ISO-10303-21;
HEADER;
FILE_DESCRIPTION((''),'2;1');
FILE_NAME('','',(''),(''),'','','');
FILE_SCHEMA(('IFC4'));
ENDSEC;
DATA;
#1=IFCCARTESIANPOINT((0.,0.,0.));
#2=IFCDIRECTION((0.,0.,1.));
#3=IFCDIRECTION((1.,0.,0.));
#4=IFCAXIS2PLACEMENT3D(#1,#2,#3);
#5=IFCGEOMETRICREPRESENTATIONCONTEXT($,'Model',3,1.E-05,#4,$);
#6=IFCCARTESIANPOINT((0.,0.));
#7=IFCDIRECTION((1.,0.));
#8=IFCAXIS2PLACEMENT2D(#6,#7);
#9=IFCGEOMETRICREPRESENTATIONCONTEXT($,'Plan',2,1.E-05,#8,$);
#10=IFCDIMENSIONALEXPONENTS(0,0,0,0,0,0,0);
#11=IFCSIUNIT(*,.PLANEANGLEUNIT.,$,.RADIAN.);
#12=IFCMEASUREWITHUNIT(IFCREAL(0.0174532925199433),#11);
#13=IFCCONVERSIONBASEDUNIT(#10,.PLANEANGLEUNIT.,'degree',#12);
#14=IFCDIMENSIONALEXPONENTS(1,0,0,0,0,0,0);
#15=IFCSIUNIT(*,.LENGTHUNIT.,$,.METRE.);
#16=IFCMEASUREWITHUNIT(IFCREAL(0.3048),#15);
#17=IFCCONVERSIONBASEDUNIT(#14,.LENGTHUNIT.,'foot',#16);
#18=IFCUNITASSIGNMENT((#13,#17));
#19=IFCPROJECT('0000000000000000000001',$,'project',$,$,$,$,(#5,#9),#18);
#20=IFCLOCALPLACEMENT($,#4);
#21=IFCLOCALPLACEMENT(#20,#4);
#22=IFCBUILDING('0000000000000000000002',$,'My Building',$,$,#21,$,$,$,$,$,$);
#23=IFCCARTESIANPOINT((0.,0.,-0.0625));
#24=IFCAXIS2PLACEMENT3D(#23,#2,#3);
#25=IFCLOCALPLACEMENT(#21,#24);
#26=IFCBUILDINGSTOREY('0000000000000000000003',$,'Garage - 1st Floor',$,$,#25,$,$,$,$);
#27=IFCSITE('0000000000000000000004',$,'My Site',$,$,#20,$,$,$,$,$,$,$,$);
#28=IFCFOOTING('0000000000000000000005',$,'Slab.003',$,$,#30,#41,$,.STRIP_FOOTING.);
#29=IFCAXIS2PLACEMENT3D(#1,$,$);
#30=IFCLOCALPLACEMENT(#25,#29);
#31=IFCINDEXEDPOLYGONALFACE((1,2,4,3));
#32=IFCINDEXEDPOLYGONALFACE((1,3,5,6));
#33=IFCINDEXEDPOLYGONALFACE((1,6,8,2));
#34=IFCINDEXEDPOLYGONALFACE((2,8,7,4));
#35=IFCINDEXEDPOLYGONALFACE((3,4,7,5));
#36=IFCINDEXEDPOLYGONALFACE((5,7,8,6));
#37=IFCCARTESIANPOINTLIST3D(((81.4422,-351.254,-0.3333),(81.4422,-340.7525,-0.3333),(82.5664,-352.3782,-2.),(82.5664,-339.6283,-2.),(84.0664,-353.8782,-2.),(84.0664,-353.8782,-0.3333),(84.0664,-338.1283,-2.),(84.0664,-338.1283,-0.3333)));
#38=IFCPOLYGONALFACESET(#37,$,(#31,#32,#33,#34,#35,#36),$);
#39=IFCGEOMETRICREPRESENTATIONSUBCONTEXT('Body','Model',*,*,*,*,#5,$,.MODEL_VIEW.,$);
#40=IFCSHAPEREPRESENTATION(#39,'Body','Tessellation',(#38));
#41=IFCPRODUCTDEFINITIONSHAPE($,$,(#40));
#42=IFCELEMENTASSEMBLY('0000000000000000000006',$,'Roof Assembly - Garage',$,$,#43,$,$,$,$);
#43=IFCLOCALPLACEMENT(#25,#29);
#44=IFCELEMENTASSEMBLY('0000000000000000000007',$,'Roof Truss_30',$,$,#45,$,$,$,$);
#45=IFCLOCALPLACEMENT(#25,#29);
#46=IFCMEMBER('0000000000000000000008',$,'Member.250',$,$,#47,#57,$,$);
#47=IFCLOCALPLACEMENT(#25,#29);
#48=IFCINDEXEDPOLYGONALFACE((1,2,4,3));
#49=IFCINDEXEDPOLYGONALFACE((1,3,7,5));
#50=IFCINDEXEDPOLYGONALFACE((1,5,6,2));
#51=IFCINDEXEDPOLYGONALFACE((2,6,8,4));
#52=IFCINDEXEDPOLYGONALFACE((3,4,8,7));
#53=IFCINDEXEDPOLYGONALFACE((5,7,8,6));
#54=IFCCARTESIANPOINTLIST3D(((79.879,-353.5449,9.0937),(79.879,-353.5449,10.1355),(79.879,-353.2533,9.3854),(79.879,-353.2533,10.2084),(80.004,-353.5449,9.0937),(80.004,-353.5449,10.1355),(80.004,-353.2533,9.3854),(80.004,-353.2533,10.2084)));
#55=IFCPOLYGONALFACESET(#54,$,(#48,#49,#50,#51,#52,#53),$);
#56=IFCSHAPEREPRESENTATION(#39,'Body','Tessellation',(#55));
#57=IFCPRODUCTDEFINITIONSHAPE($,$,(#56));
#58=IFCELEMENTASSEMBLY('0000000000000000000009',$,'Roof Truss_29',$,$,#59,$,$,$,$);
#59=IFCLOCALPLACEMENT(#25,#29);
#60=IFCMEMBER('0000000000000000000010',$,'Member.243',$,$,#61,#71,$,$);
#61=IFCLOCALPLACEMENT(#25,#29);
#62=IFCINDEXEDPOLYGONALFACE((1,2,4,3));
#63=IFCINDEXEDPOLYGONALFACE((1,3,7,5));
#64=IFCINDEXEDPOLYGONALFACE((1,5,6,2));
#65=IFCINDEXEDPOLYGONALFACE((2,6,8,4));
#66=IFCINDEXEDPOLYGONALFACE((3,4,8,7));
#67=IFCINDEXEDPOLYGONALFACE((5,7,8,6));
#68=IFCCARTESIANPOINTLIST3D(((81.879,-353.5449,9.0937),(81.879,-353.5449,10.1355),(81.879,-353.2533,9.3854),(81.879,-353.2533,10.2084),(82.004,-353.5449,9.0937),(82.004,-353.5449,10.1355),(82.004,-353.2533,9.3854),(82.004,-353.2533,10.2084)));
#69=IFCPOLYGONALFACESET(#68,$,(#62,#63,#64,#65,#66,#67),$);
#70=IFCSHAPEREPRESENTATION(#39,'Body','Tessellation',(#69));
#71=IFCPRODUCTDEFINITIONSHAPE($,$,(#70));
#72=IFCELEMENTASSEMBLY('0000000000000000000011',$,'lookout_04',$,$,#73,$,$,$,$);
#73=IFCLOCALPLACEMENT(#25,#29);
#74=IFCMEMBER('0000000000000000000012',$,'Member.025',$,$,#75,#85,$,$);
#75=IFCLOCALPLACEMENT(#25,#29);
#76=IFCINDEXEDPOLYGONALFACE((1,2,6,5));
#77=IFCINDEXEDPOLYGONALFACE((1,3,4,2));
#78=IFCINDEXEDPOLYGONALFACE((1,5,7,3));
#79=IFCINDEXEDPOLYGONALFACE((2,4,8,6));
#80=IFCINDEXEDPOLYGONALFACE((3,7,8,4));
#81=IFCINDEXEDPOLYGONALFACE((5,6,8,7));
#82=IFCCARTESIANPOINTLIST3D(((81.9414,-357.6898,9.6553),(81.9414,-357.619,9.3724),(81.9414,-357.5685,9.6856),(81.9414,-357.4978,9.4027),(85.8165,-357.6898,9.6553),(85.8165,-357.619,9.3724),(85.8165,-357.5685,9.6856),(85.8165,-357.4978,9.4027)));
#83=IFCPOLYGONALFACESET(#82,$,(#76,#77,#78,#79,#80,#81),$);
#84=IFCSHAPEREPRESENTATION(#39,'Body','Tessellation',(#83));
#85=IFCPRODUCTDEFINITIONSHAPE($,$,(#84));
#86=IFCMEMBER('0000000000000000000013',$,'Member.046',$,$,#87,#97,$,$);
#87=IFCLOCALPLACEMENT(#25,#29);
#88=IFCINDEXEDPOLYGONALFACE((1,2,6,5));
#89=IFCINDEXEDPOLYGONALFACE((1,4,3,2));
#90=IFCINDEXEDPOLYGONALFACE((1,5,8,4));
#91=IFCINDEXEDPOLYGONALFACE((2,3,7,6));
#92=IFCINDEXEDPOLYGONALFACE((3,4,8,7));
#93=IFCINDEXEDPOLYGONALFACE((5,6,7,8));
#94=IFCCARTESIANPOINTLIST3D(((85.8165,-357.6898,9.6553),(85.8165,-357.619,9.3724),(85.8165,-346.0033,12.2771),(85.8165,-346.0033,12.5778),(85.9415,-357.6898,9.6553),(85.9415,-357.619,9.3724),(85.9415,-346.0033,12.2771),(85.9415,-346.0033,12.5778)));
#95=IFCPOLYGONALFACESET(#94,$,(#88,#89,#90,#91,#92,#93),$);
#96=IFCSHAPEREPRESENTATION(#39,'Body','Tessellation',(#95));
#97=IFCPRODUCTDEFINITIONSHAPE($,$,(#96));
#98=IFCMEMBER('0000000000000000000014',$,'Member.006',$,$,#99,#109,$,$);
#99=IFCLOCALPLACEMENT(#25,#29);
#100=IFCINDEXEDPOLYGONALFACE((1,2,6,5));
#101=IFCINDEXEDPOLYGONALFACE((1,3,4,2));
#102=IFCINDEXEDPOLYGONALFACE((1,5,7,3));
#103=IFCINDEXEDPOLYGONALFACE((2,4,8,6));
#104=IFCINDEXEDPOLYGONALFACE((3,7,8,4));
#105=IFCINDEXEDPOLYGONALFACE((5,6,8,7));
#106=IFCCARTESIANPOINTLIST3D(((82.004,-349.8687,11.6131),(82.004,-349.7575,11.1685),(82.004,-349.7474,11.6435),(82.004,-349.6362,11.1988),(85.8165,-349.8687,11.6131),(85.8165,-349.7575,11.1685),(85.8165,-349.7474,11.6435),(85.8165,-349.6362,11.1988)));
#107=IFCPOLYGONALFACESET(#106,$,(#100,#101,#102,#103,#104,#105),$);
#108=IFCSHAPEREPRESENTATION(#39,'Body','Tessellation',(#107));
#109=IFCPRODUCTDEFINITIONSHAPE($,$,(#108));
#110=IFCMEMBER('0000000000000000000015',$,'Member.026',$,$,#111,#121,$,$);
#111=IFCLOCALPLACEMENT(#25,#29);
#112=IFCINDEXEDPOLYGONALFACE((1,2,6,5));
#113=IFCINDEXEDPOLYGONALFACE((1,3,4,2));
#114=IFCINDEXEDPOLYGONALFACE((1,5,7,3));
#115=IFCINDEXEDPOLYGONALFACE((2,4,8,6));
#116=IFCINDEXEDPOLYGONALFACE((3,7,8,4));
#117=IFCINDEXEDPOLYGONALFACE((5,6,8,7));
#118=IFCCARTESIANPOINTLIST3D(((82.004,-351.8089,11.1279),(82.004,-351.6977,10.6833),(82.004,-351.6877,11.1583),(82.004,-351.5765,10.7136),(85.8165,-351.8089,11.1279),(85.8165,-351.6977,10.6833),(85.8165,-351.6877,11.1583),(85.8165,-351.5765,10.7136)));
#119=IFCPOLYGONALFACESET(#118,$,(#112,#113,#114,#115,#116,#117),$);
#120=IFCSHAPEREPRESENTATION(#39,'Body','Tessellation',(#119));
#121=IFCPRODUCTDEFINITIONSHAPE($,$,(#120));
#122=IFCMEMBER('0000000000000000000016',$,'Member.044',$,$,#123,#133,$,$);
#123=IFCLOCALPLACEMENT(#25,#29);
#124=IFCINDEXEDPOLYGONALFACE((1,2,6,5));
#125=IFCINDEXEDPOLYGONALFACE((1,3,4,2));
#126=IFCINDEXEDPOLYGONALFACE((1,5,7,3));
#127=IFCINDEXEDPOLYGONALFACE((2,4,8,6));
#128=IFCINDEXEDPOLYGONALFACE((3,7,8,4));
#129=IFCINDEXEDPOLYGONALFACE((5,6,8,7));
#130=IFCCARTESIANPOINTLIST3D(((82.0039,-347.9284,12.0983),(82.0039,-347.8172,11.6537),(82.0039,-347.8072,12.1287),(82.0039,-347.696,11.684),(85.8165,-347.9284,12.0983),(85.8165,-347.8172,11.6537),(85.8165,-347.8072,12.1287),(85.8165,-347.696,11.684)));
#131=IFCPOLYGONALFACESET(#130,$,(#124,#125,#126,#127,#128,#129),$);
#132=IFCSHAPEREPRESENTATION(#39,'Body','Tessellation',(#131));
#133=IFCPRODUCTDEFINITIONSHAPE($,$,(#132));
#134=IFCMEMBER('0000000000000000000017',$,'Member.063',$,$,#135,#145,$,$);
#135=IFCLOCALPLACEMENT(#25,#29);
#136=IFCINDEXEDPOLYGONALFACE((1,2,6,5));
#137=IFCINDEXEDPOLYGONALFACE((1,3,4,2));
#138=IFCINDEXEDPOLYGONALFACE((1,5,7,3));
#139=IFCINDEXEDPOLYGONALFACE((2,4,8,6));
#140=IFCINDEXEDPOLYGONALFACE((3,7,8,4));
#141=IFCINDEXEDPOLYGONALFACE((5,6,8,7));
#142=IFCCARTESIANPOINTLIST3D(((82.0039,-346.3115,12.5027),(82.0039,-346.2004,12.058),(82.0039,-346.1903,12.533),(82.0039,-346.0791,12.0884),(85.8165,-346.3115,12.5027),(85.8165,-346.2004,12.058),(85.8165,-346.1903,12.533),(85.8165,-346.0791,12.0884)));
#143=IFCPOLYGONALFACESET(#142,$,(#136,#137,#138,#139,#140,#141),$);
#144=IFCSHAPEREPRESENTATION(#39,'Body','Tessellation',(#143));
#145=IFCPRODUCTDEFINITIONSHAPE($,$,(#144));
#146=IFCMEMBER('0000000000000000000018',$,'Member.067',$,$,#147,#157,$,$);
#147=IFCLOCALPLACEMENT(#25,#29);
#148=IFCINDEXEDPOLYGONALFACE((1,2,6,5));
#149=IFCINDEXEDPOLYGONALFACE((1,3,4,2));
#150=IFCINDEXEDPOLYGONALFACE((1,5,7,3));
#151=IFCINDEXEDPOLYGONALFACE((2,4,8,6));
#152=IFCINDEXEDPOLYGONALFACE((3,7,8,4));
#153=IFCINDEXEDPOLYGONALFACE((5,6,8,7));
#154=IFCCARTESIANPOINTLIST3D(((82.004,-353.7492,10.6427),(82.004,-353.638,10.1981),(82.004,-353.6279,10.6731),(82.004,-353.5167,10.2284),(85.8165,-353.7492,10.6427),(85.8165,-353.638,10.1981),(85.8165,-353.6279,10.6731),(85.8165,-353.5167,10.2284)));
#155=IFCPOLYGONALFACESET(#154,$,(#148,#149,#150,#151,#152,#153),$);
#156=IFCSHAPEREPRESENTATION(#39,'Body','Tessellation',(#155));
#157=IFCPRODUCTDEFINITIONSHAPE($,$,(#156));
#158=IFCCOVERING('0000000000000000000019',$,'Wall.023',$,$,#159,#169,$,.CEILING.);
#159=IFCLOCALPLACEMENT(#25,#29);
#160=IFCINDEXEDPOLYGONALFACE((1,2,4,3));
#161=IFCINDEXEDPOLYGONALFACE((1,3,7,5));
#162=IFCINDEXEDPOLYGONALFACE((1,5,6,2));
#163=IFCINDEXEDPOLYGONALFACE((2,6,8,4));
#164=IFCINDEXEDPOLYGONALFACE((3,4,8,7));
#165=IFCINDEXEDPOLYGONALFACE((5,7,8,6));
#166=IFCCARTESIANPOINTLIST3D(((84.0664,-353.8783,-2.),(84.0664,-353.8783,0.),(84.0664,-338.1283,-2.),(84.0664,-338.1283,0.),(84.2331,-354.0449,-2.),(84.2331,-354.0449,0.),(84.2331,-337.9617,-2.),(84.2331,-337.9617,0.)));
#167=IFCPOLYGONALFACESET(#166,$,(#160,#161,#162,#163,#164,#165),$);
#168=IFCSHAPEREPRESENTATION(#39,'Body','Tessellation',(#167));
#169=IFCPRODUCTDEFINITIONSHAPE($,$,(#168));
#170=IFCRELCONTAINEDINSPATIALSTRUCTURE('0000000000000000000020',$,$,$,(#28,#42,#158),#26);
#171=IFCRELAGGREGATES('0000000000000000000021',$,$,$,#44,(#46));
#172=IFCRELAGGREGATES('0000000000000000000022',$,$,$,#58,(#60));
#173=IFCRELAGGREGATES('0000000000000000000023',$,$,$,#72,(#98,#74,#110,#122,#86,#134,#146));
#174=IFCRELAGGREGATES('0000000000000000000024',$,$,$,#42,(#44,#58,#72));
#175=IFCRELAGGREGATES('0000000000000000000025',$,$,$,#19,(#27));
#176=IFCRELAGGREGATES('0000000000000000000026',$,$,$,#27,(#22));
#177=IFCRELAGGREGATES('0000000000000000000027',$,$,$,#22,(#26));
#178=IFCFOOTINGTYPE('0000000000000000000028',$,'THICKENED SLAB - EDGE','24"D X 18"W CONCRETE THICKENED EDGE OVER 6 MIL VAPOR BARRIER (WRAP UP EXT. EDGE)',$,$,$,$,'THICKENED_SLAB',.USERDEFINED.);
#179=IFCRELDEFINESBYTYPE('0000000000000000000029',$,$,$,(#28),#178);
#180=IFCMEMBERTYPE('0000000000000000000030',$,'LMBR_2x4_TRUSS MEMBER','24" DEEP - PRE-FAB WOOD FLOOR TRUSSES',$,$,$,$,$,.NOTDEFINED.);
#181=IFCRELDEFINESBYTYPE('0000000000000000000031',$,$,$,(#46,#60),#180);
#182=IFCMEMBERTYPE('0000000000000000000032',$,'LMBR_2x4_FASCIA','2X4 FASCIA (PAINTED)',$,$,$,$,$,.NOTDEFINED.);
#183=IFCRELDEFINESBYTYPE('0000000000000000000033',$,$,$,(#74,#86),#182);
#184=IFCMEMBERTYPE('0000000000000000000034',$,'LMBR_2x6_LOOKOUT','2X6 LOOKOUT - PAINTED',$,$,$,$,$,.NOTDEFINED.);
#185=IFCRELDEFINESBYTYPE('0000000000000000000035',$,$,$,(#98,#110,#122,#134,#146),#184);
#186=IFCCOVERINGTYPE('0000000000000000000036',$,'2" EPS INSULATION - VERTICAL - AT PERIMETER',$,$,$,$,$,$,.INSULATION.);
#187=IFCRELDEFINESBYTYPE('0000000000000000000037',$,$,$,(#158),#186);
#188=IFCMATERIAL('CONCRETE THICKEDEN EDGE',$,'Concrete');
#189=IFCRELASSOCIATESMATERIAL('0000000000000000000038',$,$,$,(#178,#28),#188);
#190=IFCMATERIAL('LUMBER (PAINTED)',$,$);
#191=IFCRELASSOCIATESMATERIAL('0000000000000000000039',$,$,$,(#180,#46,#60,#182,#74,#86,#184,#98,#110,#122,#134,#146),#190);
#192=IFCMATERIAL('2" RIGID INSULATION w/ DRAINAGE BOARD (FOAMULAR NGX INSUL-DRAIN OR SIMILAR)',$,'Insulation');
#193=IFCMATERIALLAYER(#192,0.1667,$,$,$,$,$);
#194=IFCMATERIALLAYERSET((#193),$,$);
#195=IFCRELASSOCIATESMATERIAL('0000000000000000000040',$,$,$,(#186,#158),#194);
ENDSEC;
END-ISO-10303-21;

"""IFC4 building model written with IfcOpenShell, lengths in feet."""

from ifc_helpers import new_model, entity, si_unit, converted_unit, frame, origin_with_axes, origin_2d_with_axis, place, context, subcontext, project, spatial, line, indexed_curve, outline, extrude, clip, halfspace, material, layer, layer_set, layer_usage, material_profile, profile_set, profile_usage, type_object, element, aggregate, save


model = new_model("IFC4")

# Units and contexts
model_context = context("Model", 3, precision=1e-05, world=origin_with_axes())
plan_context = context("Plan", 2, precision=1e-05, world=origin_2d_with_axis())
body_context = subcontext(model_context, "Body", "Model", "MODEL_VIEW")
ifc_project = project(units=[converted_unit("PLANEANGLEUNIT", "degree", entity("IfcReal", 0.0174532925199433), si_unit("PLANEANGLEUNIT", "RADIAN"), dimensions=[0, 0, 0, 0, 0, 0, 0]), converted_unit("LENGTHUNIT", "foot", entity("IfcReal", 0.3048), si_unit("LENGTHUNIT", "METRE"), dimensions=[1, 0, 0, 0, 0, 0, 0])], contexts=[model_context, plan_context])

# Site, building, storey
site_placement = place(None, origin_with_axes())
site = spatial("IfcSite", under=ifc_project, at=site_placement, Name="My Site")
building_placement = place(site_placement, origin_with_axes())
building = spatial("IfcBuilding", under=site, at=building_placement, Name="My Building")
storey_placement = place(building_placement, frame((0.0, 0.0, -0.0625), z_axis=(0.0, 0.0, 1.0), x_axis=(1.0, 0.0, 0.0)))
storey = spatial("IfcBuildingStorey", under=building, at=storey_placement, Name="Garage - 1st Floor")

# Footing
ifc_material_1 = material(Name="CONCRETE THICKEDEN EDGE", Category="Concrete")
ifc_material_profile_1 = material_profile(ifc_material_1, outline(indexed_curve([(0.0, 1.6667), (0.0, 0.0), (2.6242, 1.6667), (1.5, 0.0)], segments=[line(4, 2), line(2, 1), line(1, 3), line(3, 4)], self_intersect=False)))
ifc_profile_set_1 = profile_set([ifc_material_profile_1])
ifc_profile_usage_1 = profile_usage(ifc_profile_set_1, cardinal=5)
footing_type = type_object("IfcFootingType", Name="THICKENED SLAB - EDGE", Description="24\"D X 18\"W CONCRETE THICKENED EDGE OVER 6 MIL VAPOR BARRIER (WRAP UP EXT. EDGE)", ElementType="THICKENED_SLAB", PredefinedType="USERDEFINED", material=ifc_profile_set_1)
footing_placement = place(storey_placement, frame((84.0664, -353.8782, -2.0), z_axis=(-0.000001, 1.0, 0.0), x_axis=(-1.0, -0.000001, 0.0)))
element("IfcFooting", 1, at=footing_placement, inside=storey, type_object=footing_type, material=ifc_profile_usage_1, Name="Slab.003", PredefinedType="STRIP_FOOTING", context=body_context, shape_type="Clipping", body=[
    clip(clip(extrude(outline(indexed_curve([(0.0, 1.6667), (0.0, 0.0), (2.6242, 1.6667), (1.5, 0.0)], segments=[line(4, 2), line(2, 1), line(1, 3), line(3, 4)], self_intersect=False)), origin_with_axes(), (0.0, 0.0, 1.0), 15.7499), halfspace(frame((0.0, 2.0625, 0.0), z_axis=(0.707107, 0.0, -0.707106), x_axis=(0.0, -1.0, 0.0)), False)), halfspace(frame((0.0, 2.0625, 15.7499), z_axis=(0.707106, 0.0, 0.707107), x_axis=(0.0, -1.0, 0.0)), False)),
])

# Element assemblies, members
assembly_1_placement = place(storey_placement, frame((0.0, 0.0, 0.125), z_axis=(0.0, 0.0, 1.0), x_axis=(1.0, 0.0, 0.0)))
assembly_1 = element("IfcElementAssembly", 2, at=assembly_1_placement, inside=storey, Name="Roof Assembly - Garage")
ifc_material_2 = material(Name="LUMBER (PAINTED)")
ifc_material_profile_2 = material_profile(ifc_material_2, outline(indexed_curve([(-0.0625, -0.1458), (0.0625, -0.1458), (0.0625, 0.1458), (-0.0625, 0.1458), (-0.0625, -0.1458)])))
ifc_profile_set_2 = profile_set([ifc_material_profile_2])
member_type_1 = type_object("IfcMemberType", Name="LMBR_2x4_TRUSS MEMBER", Description="24\" DEEP - PRE-FAB WOOD FLOOR TRUSSES", PredefinedType="NOTDEFINED", material=ifc_profile_set_2)
assembly_2_placement = place(assembly_1_placement, frame((79.9415, -346.0033, 12.5192), z_axis=(0.0, 0.0, 1.0), x_axis=(0.0, 1.0, 0.0)))
assembly_2 = element("IfcElementAssembly", 3, at=assembly_2_placement, Name="Roof Truss_30")
ifc_profile_usage_2 = profile_usage(ifc_profile_set_2)
member_1_placement = place(assembly_2_placement, frame((-7.3958, 0.0, -2.1806), z_axis=(0.0, 0.0, -1.0), x_axis=(0.0, 1.0, 0.0)))
member_1 = element("IfcMember", 4, at=member_1_placement, type_object=member_type_1, material=ifc_profile_usage_2, Name="Member.250", context=body_context, shape_type="Clipping", body=[
    clip(clip(extrude(outline(indexed_curve([(-0.0625, -0.1458), (0.0625, -0.1458), (0.0625, 0.1458), (-0.0625, 0.1458), (-0.0625, -0.1458)])), origin_with_axes(), (0.0, 0.0, 1.0), 1.3698), halfspace(frame((0.0, 7.5424, -1.5944), z_axis=(0.0, -0.242599, -0.970127), x_axis=(-1.0, 0.000001, 0.0)), False)), halfspace(frame((397.5032, -0.1458, 1.3698), z_axis=(0.0, 0.707107, 0.707107), x_axis=(1.0, 0.0, 0.0)), False)),
])
assembly_3_placement = place(assembly_1_placement, frame((81.9415, -346.0033, 12.5192), z_axis=(0.0, 0.0, 1.0), x_axis=(0.0, 1.0, 0.0)))
assembly_3 = element("IfcElementAssembly", 5, at=assembly_3_placement, Name="Roof Truss_29")
ifc_profile_usage_3 = profile_usage(ifc_profile_set_2)
member_2_placement = place(assembly_3_placement, frame((-7.3958, 0.0, -2.1806), z_axis=(0.0, 0.0, -1.0), x_axis=(0.0, 1.0, 0.0)))
member_2 = element("IfcMember", 6, at=member_2_placement, type_object=member_type_1, material=ifc_profile_usage_3, Name="Member.243", context=body_context, shape_type="Clipping", body=[
    clip(clip(extrude(outline(indexed_curve([(-0.0625, -0.1458), (0.0625, -0.1458), (0.0625, 0.1458), (-0.0625, 0.1458), (-0.0625, -0.1458)])), origin_with_axes(), (0.0, 0.0, 1.0), 1.3698), halfspace(frame((0.0, 7.5424, -1.5944), z_axis=(0.0, -0.242599, -0.970127), x_axis=(-1.0, 0.000001, 0.0)), False)), halfspace(frame((397.5032, -0.1458, 1.3698), z_axis=(0.0, 0.707107, 0.707107), x_axis=(1.0, 0.0, 0.0)), False)),
])
assembly_4_placement = place(assembly_1_placement, frame((81.9414, -346.0033, 12.5192), z_axis=(0.0, 0.0, 1.0), x_axis=(0.000001, -1.0, 0.0)))
assembly_4 = element("IfcElementAssembly", 7, at=assembly_4_placement, Name="lookout_04")
aggregate(assembly_2, [member_1])
aggregate(assembly_3, [member_2])
ifc_material_profile_3 = material_profile(ifc_material_2, outline(indexed_curve([(-0.0625, -0.1458), (0.0625, -0.1458), (0.0625, 0.1458), (-0.0625, 0.1458), (-0.0625, -0.1458)])))
ifc_profile_set_3 = profile_set([ifc_material_profile_3])
ifc_profile_usage_4 = profile_usage(ifc_profile_set_3)
member_type_2 = type_object("IfcMemberType", Name="LMBR_2x4_FASCIA", Description="2X4 FASCIA (PAINTED)", PredefinedType="NOTDEFINED", material=ifc_profile_set_3)
member_3_placement = place(assembly_4_placement, frame((11.5905, 0.0, -3.1152), z_axis=(0.0, 1.0, 0.0), x_axis=(-0.970127, 0.0, 0.242599)))
member_3 = element("IfcMember", 8, at=member_3_placement, type_object=member_type_2, material=ifc_profile_usage_4, Name="Member.025", context=body_context, shape_type="SweptSolid", body=[
    extrude(outline(indexed_curve([(-0.0625, -0.1458), (0.0625, -0.1458), (0.0625, 0.1458), (-0.0625, 0.1458), (-0.0625, -0.1458)])), origin_with_axes(), (0.0, 0.0, 1.0), 3.875),
])
ifc_profile_usage_5 = profile_usage(ifc_profile_set_3)
member_4_placement = place(assembly_4_placement, frame((11.6511, 3.9375, -3.1303), z_axis=(-0.970127, 0.0, 0.242599), x_axis=(0.0, -1.0, 0.0)))
member_4 = element("IfcMember", 9, at=member_4_placement, type_object=member_type_2, material=ifc_profile_usage_5, Name="Member.046", context=body_context, shape_type="Clipping", body=[
    clip(extrude(outline(indexed_curve([(-0.0625, -0.1458), (0.0625, -0.1458), (0.0625, 0.1458), (-0.0625, 0.1458), (-0.0625, -0.1458)])), origin_with_axes(), (0.0, 0.0, 1.0), 12.6114), halfspace(frame((85.8788, 0.1458, 12.0464), z_axis=(0.0, -0.242599, 0.970127), x_axis=(-1.0, -0.000001, 0.0)), False)),
])
ifc_material_profile_4 = material_profile(ifc_material_2, outline(indexed_curve([(-0.0625, 0.2292), (0.0625, 0.2292), (0.0625, -0.2292), (-0.0625, -0.2292), (-0.0625, 0.2292)])))
ifc_profile_set_4 = profile_set([ifc_material_profile_4])
ifc_profile_usage_6 = profile_usage(ifc_profile_set_4)
member_type_3 = type_object("IfcMemberType", Name="LMBR_2x6_LOOKOUT", Description="2X6 LOOKOUT - PAINTED", PredefinedType="NOTDEFINED", material=ifc_profile_set_4)
member_5_placement = place(assembly_4_placement, frame((3.7491, 0.0625, -1.2382), z_axis=(0.0, 1.0, 0.0), x_axis=(-0.970127, 0.0, 0.242599)))
member_5 = element("IfcMember", 10, at=member_5_placement, type_object=member_type_3, material=ifc_profile_usage_6, Name="Member.006", context=body_context, shape_type="SweptSolid", body=[
    extrude(outline(indexed_curve([(-0.0625, 0.2292), (0.0625, 0.2292), (0.0625, -0.2292), (-0.0625, -0.2292), (-0.0625, 0.2292)])), origin_with_axes(), (0.0, 0.0, 1.0), 3.8125),
])
ifc_profile_usage_7 = profile_usage(ifc_profile_set_4)
member_6_placement = place(assembly_4_placement, frame((5.6894, 0.0625, -1.7234), z_axis=(0.0, 1.0, 0.0), x_axis=(-0.970127, 0.0, 0.242599)))
member_6 = element("IfcMember", 11, at=member_6_placement, type_object=member_type_3, material=ifc_profile_usage_7, Name="Member.026", context=body_context, shape_type="SweptSolid", body=[
    extrude(outline(indexed_curve([(-0.0625, 0.2292), (0.0625, 0.2292), (0.0625, -0.2292), (-0.0625, -0.2292), (-0.0625, 0.2292)])), origin_with_axes(), (0.0, 0.0, 1.0), 3.8125),
])
ifc_profile_usage_8 = profile_usage(ifc_profile_set_4)
member_7_placement = place(assembly_4_placement, frame((1.8089, 0.0625, -0.753), z_axis=(0.0, 1.0, 0.0), x_axis=(-0.970127, 0.0, 0.242599)))
member_7 = element("IfcMember", 12, at=member_7_placement, type_object=member_type_3, material=ifc_profile_usage_8, Name="Member.044", context=body_context, shape_type="SweptSolid", body=[
    extrude(outline(indexed_curve([(-0.0625, 0.2292), (0.0625, 0.2292), (0.0625, -0.2292), (-0.0625, -0.2292), (-0.0625, 0.2292)])), origin_with_axes(), (0.0, 0.0, 1.0), 3.8125),
])
ifc_profile_usage_9 = profile_usage(ifc_profile_set_4)
member_8_placement = place(assembly_4_placement, frame((0.192, 0.0625, -0.3487), z_axis=(0.0, 1.0, 0.0), x_axis=(-0.970127, 0.0, 0.242599)))
member_8 = element("IfcMember", 13, at=member_8_placement, type_object=member_type_3, material=ifc_profile_usage_9, Name="Member.063", context=body_context, shape_type="SweptSolid", body=[
    extrude(outline(indexed_curve([(-0.0625, 0.2292), (0.0625, 0.2292), (0.0625, -0.2292), (-0.0625, -0.2292), (-0.0625, 0.2292)])), origin_with_axes(), (0.0, 0.0, 1.0), 3.8125),
])
ifc_profile_usage_10 = profile_usage(ifc_profile_set_4)
member_9_placement = place(assembly_4_placement, frame((7.6296, 0.0625, -2.2086), z_axis=(0.0, 1.0, 0.0), x_axis=(-0.970127, 0.0, 0.242599)))
member_9 = element("IfcMember", 14, at=member_9_placement, type_object=member_type_3, material=ifc_profile_usage_10, Name="Member.067", context=body_context, shape_type="SweptSolid", body=[
    extrude(outline(indexed_curve([(-0.0625, 0.2292), (0.0625, 0.2292), (0.0625, -0.2292), (-0.0625, -0.2292), (-0.0625, 0.2292)])), origin_with_axes(), (0.0, 0.0, 1.0), 3.8125),
])
aggregate(assembly_4, [member_5, member_3, member_6, member_7, member_4, member_8, member_9])
aggregate(assembly_1, [assembly_2, assembly_3, assembly_4])

# Covering
ifc_material_3 = material(Name="2\" RIGID INSULATION w/ DRAINAGE BOARD (FOAMULAR NGX INSUL-DRAIN OR SIMILAR)", Category="Insulation")
ifc_layer_1 = layer(ifc_material_3, 0.1667)
ifc_layer_set_1 = layer_set([ifc_layer_1])
ifc_layer_usage_1 = layer_usage(ifc_layer_set_1, "AXIS2", "POSITIVE", 0.0)
covering_type_1 = type_object("IfcCoveringType", Name="2\" EPS INSULATION - VERTICAL - AT PERIMETER", PredefinedType="INSULATION", material=ifc_layer_set_1)
covering_1_placement = place(storey_placement, frame((84.2331, -354.0449, -2.0), z_axis=(0.0, 0.0, 1.0), x_axis=(0.0, 1.0, 0.0)))
element("IfcCovering", 15, at=covering_1_placement, inside=storey, type_object=covering_type_1, material=ifc_layer_usage_1, Name="Wall.023", PredefinedType="CEILING", context=body_context, shape_type="SweptSolid", body=[
    extrude(outline(indexed_curve([(0.0, 0.0), (0.1667, 0.1667), (15.9166, 0.1667), (16.0832, 0.0)], segments=[line(1, 2, 3, 4, 1)])), origin_with_axes(), (0.0, 0.0, 1.0), 2.0),
])

save(model, "model.ifc")
